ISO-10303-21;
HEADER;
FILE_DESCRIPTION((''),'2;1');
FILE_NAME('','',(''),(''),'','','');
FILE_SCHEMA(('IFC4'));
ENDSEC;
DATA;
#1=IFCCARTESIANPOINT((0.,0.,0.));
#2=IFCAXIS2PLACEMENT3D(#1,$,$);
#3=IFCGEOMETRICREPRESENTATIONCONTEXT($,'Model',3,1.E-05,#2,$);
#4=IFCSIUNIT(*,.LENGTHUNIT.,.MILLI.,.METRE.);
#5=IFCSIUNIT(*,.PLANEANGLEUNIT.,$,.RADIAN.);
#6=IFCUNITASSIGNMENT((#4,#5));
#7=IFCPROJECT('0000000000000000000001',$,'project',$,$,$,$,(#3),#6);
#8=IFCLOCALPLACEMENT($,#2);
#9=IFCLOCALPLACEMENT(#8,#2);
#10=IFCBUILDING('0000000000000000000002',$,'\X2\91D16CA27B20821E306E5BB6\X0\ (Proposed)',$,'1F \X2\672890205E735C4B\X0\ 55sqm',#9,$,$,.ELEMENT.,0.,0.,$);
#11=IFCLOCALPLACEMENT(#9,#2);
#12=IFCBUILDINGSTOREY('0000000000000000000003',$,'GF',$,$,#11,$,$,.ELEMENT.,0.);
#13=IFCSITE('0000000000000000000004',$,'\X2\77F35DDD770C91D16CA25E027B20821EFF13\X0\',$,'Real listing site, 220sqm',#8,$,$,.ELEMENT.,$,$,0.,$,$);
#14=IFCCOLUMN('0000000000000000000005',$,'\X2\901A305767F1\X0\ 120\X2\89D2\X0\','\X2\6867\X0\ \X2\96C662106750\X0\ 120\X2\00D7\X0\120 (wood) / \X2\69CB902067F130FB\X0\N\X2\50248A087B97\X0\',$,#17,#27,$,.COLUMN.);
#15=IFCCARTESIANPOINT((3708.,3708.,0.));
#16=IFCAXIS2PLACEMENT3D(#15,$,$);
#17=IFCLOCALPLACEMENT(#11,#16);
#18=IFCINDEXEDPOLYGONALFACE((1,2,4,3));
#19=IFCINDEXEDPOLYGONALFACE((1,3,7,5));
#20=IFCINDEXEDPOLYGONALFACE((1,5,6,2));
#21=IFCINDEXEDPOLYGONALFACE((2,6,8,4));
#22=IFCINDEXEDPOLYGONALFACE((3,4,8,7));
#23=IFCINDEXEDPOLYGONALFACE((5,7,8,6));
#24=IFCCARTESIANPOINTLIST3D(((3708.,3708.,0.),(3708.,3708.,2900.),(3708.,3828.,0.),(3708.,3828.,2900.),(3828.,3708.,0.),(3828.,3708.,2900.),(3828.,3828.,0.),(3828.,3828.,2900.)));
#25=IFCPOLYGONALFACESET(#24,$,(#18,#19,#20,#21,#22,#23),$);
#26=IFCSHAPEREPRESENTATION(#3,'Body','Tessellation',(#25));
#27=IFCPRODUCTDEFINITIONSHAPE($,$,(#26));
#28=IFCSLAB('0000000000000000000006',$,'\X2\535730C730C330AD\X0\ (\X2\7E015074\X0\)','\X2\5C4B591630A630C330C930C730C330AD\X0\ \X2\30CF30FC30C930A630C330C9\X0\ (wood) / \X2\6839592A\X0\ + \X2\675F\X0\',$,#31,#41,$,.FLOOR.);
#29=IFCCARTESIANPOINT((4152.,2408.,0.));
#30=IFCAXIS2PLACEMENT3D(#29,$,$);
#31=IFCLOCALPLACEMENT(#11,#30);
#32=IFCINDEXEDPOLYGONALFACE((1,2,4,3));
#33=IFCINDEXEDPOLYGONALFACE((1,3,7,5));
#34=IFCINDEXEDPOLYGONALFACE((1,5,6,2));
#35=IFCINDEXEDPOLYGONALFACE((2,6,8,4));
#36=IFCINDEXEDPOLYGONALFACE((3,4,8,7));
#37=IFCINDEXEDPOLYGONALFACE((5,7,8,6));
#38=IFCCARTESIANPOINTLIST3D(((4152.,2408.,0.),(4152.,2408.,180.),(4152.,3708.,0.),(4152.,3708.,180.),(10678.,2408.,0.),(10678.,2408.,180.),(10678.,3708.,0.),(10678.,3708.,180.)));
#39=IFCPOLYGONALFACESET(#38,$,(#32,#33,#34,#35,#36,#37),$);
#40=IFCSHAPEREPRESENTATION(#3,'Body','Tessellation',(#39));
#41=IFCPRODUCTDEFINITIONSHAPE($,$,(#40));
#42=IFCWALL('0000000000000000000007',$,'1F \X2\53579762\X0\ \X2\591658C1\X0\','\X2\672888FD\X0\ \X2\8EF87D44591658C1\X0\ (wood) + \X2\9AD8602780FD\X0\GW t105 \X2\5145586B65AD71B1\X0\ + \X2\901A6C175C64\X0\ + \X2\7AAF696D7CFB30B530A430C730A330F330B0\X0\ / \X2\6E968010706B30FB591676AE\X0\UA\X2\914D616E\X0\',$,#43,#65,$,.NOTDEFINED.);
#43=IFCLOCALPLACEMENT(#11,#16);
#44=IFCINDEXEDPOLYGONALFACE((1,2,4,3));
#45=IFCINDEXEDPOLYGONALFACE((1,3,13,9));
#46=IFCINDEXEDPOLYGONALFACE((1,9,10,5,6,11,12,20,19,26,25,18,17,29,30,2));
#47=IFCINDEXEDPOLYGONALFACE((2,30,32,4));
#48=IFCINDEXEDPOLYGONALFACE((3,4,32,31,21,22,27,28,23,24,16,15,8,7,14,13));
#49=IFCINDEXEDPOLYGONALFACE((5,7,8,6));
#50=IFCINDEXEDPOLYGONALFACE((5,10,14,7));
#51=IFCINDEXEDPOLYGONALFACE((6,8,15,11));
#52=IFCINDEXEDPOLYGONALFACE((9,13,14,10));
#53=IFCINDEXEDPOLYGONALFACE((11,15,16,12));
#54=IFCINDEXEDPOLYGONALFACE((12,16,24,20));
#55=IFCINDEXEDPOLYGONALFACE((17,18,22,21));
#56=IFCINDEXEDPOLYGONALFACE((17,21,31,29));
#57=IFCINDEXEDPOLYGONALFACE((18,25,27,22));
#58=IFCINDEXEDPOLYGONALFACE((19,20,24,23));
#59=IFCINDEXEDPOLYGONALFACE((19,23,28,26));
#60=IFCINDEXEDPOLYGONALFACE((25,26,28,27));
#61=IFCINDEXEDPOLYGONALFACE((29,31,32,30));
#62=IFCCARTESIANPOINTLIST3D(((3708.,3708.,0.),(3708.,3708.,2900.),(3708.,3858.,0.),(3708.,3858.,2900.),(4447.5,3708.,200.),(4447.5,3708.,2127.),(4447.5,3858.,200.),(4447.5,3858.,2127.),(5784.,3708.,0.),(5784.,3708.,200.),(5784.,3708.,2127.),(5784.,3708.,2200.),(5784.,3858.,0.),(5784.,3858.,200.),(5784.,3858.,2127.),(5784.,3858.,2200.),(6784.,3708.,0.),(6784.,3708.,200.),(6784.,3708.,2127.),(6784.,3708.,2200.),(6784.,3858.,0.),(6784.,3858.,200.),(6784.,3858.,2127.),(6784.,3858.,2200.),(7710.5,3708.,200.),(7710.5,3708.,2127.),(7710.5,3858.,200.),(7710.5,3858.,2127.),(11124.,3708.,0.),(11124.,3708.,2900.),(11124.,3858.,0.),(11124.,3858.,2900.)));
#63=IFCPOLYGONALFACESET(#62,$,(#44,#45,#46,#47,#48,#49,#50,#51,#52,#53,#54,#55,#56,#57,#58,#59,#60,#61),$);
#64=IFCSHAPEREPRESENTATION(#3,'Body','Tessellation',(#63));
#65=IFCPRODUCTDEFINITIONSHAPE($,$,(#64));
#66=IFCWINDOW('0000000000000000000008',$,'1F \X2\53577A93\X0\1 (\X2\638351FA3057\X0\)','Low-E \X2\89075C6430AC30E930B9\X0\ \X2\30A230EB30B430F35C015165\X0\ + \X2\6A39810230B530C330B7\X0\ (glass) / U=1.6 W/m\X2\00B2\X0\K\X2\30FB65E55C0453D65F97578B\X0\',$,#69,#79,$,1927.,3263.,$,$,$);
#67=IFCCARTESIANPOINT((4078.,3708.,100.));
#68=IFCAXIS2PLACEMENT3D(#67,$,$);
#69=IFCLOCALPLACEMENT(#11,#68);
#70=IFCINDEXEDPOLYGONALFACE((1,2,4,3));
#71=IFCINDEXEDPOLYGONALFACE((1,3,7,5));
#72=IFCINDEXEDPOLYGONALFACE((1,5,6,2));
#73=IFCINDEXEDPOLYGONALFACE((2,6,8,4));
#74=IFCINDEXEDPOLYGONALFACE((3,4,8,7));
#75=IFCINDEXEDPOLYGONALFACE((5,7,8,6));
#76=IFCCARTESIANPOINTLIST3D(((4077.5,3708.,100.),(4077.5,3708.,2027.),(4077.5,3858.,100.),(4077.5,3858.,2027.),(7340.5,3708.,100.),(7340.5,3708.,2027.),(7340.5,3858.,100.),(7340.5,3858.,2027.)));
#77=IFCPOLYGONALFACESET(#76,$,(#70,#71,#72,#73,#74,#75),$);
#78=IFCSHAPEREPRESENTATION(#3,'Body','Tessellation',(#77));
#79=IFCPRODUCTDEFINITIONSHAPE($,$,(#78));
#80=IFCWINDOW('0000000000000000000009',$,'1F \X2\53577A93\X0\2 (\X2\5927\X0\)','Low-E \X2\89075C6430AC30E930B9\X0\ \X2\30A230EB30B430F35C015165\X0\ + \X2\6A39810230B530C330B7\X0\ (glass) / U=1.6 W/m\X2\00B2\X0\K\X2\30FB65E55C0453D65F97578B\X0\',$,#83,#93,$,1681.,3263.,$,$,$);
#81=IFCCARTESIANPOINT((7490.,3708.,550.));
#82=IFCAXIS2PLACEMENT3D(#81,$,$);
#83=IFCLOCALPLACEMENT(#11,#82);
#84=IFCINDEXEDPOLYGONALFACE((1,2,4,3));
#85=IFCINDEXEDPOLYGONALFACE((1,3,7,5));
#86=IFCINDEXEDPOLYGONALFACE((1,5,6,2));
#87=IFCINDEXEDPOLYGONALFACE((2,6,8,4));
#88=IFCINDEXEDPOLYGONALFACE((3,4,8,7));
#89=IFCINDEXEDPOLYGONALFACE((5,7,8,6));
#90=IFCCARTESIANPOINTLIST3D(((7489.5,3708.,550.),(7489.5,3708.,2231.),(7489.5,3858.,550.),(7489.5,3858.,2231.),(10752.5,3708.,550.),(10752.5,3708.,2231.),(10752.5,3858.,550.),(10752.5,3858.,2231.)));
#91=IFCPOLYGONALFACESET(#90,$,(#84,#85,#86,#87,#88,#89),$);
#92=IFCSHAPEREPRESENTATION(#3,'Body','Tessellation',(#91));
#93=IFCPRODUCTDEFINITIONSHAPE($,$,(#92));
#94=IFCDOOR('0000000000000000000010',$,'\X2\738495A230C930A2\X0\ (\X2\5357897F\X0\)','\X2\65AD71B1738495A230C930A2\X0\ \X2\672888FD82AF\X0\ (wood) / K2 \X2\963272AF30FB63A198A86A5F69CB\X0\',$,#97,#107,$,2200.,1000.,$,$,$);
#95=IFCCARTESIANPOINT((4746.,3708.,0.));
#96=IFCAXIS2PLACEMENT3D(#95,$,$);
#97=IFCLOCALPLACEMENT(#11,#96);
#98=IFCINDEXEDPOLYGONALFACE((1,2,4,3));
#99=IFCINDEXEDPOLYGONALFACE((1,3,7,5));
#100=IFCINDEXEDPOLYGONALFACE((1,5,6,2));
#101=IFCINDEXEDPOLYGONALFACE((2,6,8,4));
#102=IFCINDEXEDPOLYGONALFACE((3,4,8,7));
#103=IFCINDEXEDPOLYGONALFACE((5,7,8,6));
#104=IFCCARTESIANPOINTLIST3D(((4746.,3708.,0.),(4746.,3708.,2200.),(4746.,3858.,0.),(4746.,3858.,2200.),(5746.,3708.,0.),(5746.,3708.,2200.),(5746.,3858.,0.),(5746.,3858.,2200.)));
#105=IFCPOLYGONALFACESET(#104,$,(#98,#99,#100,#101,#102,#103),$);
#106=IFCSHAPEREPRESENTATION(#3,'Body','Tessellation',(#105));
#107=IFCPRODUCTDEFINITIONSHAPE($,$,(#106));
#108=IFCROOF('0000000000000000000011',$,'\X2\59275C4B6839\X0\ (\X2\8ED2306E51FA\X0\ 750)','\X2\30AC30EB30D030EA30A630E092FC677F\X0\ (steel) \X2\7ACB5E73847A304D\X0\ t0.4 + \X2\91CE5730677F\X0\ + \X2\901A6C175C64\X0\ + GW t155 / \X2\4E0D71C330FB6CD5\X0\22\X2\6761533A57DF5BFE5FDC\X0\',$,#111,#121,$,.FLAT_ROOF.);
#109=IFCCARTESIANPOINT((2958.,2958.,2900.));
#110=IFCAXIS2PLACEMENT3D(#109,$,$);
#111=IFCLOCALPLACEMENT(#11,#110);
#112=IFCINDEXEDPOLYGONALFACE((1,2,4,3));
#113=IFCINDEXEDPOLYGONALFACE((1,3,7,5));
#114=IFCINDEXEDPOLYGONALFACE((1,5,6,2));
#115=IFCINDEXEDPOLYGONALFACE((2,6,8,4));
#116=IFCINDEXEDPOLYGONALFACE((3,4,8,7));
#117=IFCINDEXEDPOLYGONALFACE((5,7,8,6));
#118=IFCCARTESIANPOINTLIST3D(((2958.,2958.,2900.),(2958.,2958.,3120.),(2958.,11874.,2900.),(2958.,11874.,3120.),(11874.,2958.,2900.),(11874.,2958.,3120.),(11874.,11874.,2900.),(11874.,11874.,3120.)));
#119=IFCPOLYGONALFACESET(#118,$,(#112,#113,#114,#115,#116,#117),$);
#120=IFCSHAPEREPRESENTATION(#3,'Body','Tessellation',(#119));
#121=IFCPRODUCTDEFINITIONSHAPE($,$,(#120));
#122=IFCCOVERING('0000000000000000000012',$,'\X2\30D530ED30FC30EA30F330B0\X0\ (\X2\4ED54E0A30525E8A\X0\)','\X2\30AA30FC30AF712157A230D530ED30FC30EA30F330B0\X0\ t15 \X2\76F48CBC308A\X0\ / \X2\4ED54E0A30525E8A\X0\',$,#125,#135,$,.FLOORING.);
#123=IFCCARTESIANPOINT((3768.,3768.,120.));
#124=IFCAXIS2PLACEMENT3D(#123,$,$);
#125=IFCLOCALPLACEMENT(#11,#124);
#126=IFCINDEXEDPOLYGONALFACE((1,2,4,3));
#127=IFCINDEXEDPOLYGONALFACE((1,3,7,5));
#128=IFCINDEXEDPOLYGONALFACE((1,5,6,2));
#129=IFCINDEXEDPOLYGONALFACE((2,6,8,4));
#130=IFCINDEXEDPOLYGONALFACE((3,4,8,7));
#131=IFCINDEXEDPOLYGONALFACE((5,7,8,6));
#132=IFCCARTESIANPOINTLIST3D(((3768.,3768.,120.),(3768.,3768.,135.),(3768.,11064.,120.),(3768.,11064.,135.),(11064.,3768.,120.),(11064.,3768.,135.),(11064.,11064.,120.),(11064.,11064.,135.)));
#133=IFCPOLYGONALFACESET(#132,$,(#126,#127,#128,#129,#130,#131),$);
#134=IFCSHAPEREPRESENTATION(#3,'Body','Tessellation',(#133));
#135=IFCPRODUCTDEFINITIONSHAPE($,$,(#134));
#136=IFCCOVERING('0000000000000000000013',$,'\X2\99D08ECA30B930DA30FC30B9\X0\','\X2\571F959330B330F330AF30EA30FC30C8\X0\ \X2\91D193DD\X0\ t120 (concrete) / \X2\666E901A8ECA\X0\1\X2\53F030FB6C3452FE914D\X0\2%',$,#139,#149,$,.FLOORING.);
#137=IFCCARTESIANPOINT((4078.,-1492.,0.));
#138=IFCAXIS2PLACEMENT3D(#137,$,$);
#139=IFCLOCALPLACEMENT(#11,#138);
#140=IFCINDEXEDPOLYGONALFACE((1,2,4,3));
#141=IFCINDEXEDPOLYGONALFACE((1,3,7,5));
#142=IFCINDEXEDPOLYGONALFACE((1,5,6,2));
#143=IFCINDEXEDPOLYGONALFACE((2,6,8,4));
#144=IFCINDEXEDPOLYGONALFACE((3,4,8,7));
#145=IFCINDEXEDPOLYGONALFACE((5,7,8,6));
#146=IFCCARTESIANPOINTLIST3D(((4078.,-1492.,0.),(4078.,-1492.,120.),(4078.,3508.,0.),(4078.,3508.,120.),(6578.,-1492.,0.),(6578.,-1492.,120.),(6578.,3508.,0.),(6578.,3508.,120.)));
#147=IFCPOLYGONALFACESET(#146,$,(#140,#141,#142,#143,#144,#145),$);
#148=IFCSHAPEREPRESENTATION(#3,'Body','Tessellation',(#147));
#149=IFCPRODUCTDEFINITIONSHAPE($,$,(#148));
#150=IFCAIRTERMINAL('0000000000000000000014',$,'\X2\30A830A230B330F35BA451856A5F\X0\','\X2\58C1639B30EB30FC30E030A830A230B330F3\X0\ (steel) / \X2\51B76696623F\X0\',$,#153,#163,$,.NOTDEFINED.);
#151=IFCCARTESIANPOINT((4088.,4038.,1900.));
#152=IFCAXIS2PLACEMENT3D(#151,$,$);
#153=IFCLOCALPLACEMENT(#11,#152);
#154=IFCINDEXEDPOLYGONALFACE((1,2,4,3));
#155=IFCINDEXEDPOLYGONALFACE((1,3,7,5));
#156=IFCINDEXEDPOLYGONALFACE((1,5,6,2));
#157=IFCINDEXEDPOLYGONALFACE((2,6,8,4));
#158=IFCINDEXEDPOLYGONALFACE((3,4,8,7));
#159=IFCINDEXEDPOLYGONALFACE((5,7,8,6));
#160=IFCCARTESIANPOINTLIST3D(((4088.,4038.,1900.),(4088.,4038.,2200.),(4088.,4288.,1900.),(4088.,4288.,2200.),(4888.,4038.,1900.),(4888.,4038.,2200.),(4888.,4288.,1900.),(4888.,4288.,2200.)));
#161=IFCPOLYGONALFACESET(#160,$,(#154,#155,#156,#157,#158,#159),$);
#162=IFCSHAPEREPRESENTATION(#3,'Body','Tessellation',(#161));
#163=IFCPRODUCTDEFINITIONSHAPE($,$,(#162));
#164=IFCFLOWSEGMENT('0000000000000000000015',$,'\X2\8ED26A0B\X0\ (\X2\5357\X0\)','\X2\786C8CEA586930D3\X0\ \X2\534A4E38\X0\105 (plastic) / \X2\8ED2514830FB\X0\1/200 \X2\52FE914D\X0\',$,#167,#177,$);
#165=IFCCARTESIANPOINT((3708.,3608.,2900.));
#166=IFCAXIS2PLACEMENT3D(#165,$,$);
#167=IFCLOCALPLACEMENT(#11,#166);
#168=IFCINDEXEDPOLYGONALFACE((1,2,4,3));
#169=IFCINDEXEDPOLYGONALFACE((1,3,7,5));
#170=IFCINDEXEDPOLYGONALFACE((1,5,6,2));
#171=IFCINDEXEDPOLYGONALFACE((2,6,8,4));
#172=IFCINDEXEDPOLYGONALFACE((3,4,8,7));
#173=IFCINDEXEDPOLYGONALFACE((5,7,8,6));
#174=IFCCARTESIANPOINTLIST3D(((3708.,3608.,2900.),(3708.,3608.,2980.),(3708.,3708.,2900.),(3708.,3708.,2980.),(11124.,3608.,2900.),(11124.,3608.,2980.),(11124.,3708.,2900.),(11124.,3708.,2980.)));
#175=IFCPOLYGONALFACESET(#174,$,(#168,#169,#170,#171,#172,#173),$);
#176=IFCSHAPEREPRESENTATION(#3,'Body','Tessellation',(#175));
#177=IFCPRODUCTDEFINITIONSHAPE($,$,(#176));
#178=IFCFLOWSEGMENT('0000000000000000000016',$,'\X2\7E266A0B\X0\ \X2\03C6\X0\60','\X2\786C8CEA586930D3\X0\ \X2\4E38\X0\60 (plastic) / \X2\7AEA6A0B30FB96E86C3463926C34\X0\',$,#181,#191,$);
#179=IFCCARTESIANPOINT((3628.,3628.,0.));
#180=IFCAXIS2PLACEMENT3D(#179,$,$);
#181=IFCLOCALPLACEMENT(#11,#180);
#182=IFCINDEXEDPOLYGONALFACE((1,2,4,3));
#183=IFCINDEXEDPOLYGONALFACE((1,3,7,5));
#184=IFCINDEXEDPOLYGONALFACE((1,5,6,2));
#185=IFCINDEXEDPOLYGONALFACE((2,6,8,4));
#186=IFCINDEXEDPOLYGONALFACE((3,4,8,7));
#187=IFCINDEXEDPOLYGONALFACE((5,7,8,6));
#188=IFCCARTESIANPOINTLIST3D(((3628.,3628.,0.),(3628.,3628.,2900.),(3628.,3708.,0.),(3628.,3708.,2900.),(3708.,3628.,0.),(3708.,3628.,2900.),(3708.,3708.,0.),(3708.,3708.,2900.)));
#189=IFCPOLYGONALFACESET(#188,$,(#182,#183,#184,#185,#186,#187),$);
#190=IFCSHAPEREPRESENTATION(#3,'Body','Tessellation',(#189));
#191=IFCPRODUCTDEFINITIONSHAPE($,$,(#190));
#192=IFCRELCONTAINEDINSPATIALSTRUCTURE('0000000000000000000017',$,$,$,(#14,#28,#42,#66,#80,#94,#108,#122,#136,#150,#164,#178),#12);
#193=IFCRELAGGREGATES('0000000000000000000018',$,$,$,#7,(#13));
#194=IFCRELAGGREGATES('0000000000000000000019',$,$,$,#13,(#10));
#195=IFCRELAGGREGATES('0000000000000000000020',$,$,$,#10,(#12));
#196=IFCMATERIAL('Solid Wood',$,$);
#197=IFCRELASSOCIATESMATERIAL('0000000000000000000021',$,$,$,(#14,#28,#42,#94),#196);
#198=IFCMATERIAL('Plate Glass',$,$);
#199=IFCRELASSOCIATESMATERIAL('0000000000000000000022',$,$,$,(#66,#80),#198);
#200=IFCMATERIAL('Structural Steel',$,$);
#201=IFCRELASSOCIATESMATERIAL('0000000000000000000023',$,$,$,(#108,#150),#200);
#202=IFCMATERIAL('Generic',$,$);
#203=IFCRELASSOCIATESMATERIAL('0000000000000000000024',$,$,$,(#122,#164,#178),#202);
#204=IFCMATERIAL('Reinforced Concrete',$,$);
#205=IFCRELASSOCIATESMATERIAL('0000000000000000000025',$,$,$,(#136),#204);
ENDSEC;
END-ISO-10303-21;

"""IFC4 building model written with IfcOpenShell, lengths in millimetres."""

from ifc_helpers import new_model, si_unit, frame, frame_2d, origin, place, context, project, spatial, rectangle, extrude, material, element, fill, save


model = new_model("IFC4")

# Units and contexts
model_context = context("Model", 3, precision=1e-05, world=origin())
ifc_project = project(units=[si_unit("LENGTHUNIT", "METRE", prefix="MILLI"), si_unit("PLANEANGLEUNIT", "RADIAN")], contexts=[model_context])

# Site, building, storey
site_placement = place(None, origin())
site = spatial("IfcSite", under=ifc_project, at=site_placement, Name="石川県金沢市笠舞３", ObjectType="Real listing site, 220sqm", CompositionType="ELEMENT", RefElevation=0.0)
building_placement = place(site_placement, origin())
building = spatial("IfcBuilding", under=site, at=building_placement, Name="金沢笠舞の家 (Proposed)", ObjectType="1F 木造平屋 55sqm", CompositionType="ELEMENT", ElevationOfRefHeight=0.0, ElevationOfTerrain=0.0)
storey_placement = place(building_placement, origin())
storey = spatial("IfcBuildingStorey", under=building, at=storey_placement, Name="GF", CompositionType="ELEMENT", Elevation=0.0)

# Column
ifc_material_1 = material(Name="Solid Wood")
column_placement = place(storey_placement, frame((3708.0, 3708.0, 0.0)))
element("IfcColumn", 1, at=column_placement, inside=storey, material=ifc_material_1, Name="通し柱 120角", Description="桧 集成材 120×120 (wood) / 構造柱・N値計算", PredefinedType="COLUMN", context=model_context, shape_type="SweptSolid", body=[
    extrude(rectangle(XDim=120.0, YDim=120.0, at=frame_2d((60.0, 60.0))), frame((3708.0, 3708.0, 0.0)), (0.0, 0.0, 1.0), 2900.0),
])

# Slab
ifc_material_2 = material(Name="Reinforced Concrete")
slab_1_placement = place(storey_placement, frame((4152.0, 2408.0, 0.0)))
element("IfcSlab", 2, at=slab_1_placement, inside=storey, material=ifc_material_1, Name="南デッキ (縁側)", Description="屋外ウッドデッキ ハードウッド (wood) / 根太 + 束", PredefinedType="FLOOR", context=model_context, shape_type="SweptSolid", body=[
    extrude(rectangle(XDim=6526.0, YDim=1300.0, at=frame_2d((3263.0, 650.0))), frame((4152.0, 2408.0, 0.0)), (0.0, 0.0, 1.0), 180.0),
])

# Wall, openings, windows, door
wall_1_placement = place(storey_placement, frame((3708.0, 3708.0, 0.0)))
wall_1 = element("IfcWall", 3, at=wall_1_placement, inside=storey, material=ifc_material_1, Name="1F 南面 外壁", Description="木製 軸組外壁 (wood) + 高性能GW t105 充填断熱 + 通気層 + 窯業系サイディング / 準耐火・外皮UA配慮", PredefinedType="NOTDEFINED", context=model_context, shape_type="SweptSolid", body=[
    extrude(rectangle(XDim=7416.0, YDim=150.0, at=frame_2d((3708.0, 75.0))), frame((3708.0, 3708.0, 0.0)), (0.0, 0.0, 1.0), 2900.0),
])
opening_1_placement = place(storey_placement, frame((4078.0, 3708.0, 100.0)))
opening_1 = element("IfcOpeningElement", 4, at=opening_1_placement, cuts=wall_1, PredefinedType="NOTDEFINED", context=model_context, shape_type="SweptSolid", body=[
    extrude(rectangle(XDim=3263.0, YDim=150.0, at=frame_2d((1631.0, 75.0))), frame((4078.0, 3708.0, 100.0)), (0.0, 0.0, 1.0), 1927.0),
])
opening_2_placement = place(storey_placement, frame((7490.0, 3708.0, 550.0)))
opening_2 = element("IfcOpeningElement", 5, at=opening_2_placement, cuts=wall_1, PredefinedType="NOTDEFINED", context=model_context, shape_type="SweptSolid", body=[
    extrude(rectangle(XDim=3263.0, YDim=150.0, at=frame_2d((1631.0, 75.0))), frame((7490.0, 3708.0, 550.0)), (0.0, 0.0, 1.0), 1681.0),
])
opening_3_placement = place(storey_placement, frame((4746.0, 3708.0, 0.0)))
opening_3 = element("IfcOpeningElement", 6, at=opening_3_placement, cuts=wall_1, PredefinedType="NOTDEFINED", context=model_context, shape_type="SweptSolid", body=[
    extrude(rectangle(XDim=1000.0, YDim=150.0, at=frame_2d((500.0, 75.0))), frame((4746.0, 3708.0, 0.0)), (0.0, 0.0, 1.0), 2200.0),
])
ifc_material_3 = material(Name="Plate Glass")
window_1_placement = place(storey_placement, frame((4078.0, 3708.0, 100.0)))
window_1 = element("IfcWindow", 7, at=window_1_placement, inside=storey, material=ifc_material_3, Name="1F 南窓1 (掃出し)", Description="Low-E 複層ガラス アルゴン封入 + 樹脂サッシ (glass) / U=1.6 W/m²K・日射取得型", OverallHeight=1927.0, OverallWidth=3263.0, context=model_context, shape_type="SweptSolid", body=[
    extrude(rectangle(XDim=3263.0, YDim=150.0, at=frame_2d((1631.0, 75.0))), frame((4078.0, 3708.0, 100.0)), (0.0, 0.0, 1.0), 1927.0),
])
fill(opening_1, window_1)
window_2_placement = place(storey_placement, frame((7490.0, 3708.0, 550.0)))
window_2 = element("IfcWindow", 8, at=window_2_placement, inside=storey, material=ifc_material_3, Name="1F 南窓2 (大)", Description="Low-E 複層ガラス アルゴン封入 + 樹脂サッシ (glass) / U=1.6 W/m²K・日射取得型", OverallHeight=1681.0, OverallWidth=3263.0, context=model_context, shape_type="SweptSolid", body=[
    extrude(rectangle(XDim=3263.0, YDim=150.0, at=frame_2d((1631.0, 75.0))), frame((7490.0, 3708.0, 550.0)), (0.0, 0.0, 1.0), 1681.0),
])
fill(opening_2, window_2)
door_placement = place(storey_placement, frame((4746.0, 3708.0, 0.0)))
door = element("IfcDoor", 9, at=door_placement, inside=storey, material=ifc_material_1, Name="玄関ドア (南西)", Description="断熱玄関ドア 木製芯 (wood) / K2 防犯・採風機構", OverallHeight=2200.0, OverallWidth=1000.0, context=model_context, shape_type="SweptSolid", body=[
    extrude(rectangle(XDim=1000.0, YDim=150.0, at=frame_2d((500.0, 75.0))), frame((4746.0, 3708.0, 0.0)), (0.0, 0.0, 1.0), 2200.0),
])
fill(opening_3, door)

# Roof
ifc_material_4 = material(Name="Structural Steel")
roof_placement = place(storey_placement, frame((2958.0, 2958.0, 2900.0)))
element("IfcRoof", 10, at=roof_placement, inside=storey, material=ifc_material_4, Name="大屋根 (軒の出 750)", Description="ガルバリウム鋼板 (steel) 立平葺き t0.4 + 野地板 + 通気層 + GW t155 / 不燃・法22条区域対応", PredefinedType="FLAT_ROOF", context=model_context, shape_type="SweptSolid", body=[
    extrude(rectangle(XDim=8916.0, YDim=8916.0, at=frame_2d((4458.0, 4458.0))), frame((2958.0, 2958.0, 2900.0)), (0.0, 0.0, 1.0), 220.0),
])

# Coverings
ifc_material_5 = material(Name="Generic")
covering_1_placement = place(storey_placement, frame((3768.0, 3768.0, 120.0)))
element("IfcCovering", 11, at=covering_1_placement, inside=storey, material=ifc_material_5, Name="フローリング (仕上げ床)", Description="オーク無垢フローリング t15 直貼り / 仕上げ床", PredefinedType="FLOORING", context=model_context, shape_type="SweptSolid", body=[
    extrude(rectangle(XDim=7296.0, YDim=7296.0, at=frame_2d((3648.0, 3648.0))), frame((3768.0, 3768.0, 120.0)), (0.0, 0.0, 1.0), 15.0),
])
covering_2_placement = place(storey_placement, frame((4078.0, -1492.0, 0.0)))
element("IfcCovering", 12, at=covering_2_placement, inside=storey, material=ifc_material_2, Name="駐車スペース", Description="土間コンクリート 金鏝 t120 (concrete) / 普通車1台・水勾配2%", PredefinedType="FLOORING", context=model_context, shape_type="SweptSolid", body=[
    extrude(rectangle(XDim=2500.0, YDim=5000.0, at=frame_2d((1250.0, 2500.0))), frame((4078.0, -1492.0, 0.0)), (0.0, 0.0, 1.0), 120.0),
])

# Air terminal
air_terminal_placement = place(storey_placement, frame((4088.0, 4038.0, 1900.0)))
element("IfcAirTerminal", 13, at=air_terminal_placement, inside=storey, material=ifc_material_4, Name="エアコン室内機", Description="壁掛ルームエアコン (steel) / 冷暖房", PredefinedType="NOTDEFINED", context=model_context, shape_type="SweptSolid", body=[
    extrude(rectangle(XDim=800.0, YDim=250.0, at=frame_2d((400.0, 125.0))), frame((4088.0, 4038.0, 1900.0)), (0.0, 0.0, 1.0), 300.0),
])

# Flow segments
flow_segment_1_placement = place(storey_placement, frame((3708.0, 3608.0, 2900.0)))
element("IfcFlowSegment", 14, at=flow_segment_1_placement, inside=storey, material=ifc_material_5, Name="軒樋 (南)", Description="硬質塩ビ 半丸105 (plastic) / 軒先・1/200 勾配", context=model_context, shape_type="SweptSolid", body=[
    extrude(rectangle(XDim=7416.0, YDim=100.0, at=frame_2d((3708.0, 50.0))), frame((3708.0, 3608.0, 2900.0)), (0.0, 0.0, 1.0), 80.0),
])
flow_segment_2_placement = place(storey_placement, frame((3628.0, 3628.0, 0.0)))
element("IfcFlowSegment", 15, at=flow_segment_2_placement, inside=storey, material=ifc_material_5, Name="縦樋 φ60", Description="硬質塩ビ 丸60 (plastic) / 竪樋・雨水排水", context=model_context, shape_type="SweptSolid", body=[
    extrude(rectangle(XDim=80.0, YDim=80.0, at=frame_2d((40.0, 40.0))), frame((3628.0, 3628.0, 0.0)), (0.0, 0.0, 1.0), 2900.0),
])

save(model, "model.ifc")
